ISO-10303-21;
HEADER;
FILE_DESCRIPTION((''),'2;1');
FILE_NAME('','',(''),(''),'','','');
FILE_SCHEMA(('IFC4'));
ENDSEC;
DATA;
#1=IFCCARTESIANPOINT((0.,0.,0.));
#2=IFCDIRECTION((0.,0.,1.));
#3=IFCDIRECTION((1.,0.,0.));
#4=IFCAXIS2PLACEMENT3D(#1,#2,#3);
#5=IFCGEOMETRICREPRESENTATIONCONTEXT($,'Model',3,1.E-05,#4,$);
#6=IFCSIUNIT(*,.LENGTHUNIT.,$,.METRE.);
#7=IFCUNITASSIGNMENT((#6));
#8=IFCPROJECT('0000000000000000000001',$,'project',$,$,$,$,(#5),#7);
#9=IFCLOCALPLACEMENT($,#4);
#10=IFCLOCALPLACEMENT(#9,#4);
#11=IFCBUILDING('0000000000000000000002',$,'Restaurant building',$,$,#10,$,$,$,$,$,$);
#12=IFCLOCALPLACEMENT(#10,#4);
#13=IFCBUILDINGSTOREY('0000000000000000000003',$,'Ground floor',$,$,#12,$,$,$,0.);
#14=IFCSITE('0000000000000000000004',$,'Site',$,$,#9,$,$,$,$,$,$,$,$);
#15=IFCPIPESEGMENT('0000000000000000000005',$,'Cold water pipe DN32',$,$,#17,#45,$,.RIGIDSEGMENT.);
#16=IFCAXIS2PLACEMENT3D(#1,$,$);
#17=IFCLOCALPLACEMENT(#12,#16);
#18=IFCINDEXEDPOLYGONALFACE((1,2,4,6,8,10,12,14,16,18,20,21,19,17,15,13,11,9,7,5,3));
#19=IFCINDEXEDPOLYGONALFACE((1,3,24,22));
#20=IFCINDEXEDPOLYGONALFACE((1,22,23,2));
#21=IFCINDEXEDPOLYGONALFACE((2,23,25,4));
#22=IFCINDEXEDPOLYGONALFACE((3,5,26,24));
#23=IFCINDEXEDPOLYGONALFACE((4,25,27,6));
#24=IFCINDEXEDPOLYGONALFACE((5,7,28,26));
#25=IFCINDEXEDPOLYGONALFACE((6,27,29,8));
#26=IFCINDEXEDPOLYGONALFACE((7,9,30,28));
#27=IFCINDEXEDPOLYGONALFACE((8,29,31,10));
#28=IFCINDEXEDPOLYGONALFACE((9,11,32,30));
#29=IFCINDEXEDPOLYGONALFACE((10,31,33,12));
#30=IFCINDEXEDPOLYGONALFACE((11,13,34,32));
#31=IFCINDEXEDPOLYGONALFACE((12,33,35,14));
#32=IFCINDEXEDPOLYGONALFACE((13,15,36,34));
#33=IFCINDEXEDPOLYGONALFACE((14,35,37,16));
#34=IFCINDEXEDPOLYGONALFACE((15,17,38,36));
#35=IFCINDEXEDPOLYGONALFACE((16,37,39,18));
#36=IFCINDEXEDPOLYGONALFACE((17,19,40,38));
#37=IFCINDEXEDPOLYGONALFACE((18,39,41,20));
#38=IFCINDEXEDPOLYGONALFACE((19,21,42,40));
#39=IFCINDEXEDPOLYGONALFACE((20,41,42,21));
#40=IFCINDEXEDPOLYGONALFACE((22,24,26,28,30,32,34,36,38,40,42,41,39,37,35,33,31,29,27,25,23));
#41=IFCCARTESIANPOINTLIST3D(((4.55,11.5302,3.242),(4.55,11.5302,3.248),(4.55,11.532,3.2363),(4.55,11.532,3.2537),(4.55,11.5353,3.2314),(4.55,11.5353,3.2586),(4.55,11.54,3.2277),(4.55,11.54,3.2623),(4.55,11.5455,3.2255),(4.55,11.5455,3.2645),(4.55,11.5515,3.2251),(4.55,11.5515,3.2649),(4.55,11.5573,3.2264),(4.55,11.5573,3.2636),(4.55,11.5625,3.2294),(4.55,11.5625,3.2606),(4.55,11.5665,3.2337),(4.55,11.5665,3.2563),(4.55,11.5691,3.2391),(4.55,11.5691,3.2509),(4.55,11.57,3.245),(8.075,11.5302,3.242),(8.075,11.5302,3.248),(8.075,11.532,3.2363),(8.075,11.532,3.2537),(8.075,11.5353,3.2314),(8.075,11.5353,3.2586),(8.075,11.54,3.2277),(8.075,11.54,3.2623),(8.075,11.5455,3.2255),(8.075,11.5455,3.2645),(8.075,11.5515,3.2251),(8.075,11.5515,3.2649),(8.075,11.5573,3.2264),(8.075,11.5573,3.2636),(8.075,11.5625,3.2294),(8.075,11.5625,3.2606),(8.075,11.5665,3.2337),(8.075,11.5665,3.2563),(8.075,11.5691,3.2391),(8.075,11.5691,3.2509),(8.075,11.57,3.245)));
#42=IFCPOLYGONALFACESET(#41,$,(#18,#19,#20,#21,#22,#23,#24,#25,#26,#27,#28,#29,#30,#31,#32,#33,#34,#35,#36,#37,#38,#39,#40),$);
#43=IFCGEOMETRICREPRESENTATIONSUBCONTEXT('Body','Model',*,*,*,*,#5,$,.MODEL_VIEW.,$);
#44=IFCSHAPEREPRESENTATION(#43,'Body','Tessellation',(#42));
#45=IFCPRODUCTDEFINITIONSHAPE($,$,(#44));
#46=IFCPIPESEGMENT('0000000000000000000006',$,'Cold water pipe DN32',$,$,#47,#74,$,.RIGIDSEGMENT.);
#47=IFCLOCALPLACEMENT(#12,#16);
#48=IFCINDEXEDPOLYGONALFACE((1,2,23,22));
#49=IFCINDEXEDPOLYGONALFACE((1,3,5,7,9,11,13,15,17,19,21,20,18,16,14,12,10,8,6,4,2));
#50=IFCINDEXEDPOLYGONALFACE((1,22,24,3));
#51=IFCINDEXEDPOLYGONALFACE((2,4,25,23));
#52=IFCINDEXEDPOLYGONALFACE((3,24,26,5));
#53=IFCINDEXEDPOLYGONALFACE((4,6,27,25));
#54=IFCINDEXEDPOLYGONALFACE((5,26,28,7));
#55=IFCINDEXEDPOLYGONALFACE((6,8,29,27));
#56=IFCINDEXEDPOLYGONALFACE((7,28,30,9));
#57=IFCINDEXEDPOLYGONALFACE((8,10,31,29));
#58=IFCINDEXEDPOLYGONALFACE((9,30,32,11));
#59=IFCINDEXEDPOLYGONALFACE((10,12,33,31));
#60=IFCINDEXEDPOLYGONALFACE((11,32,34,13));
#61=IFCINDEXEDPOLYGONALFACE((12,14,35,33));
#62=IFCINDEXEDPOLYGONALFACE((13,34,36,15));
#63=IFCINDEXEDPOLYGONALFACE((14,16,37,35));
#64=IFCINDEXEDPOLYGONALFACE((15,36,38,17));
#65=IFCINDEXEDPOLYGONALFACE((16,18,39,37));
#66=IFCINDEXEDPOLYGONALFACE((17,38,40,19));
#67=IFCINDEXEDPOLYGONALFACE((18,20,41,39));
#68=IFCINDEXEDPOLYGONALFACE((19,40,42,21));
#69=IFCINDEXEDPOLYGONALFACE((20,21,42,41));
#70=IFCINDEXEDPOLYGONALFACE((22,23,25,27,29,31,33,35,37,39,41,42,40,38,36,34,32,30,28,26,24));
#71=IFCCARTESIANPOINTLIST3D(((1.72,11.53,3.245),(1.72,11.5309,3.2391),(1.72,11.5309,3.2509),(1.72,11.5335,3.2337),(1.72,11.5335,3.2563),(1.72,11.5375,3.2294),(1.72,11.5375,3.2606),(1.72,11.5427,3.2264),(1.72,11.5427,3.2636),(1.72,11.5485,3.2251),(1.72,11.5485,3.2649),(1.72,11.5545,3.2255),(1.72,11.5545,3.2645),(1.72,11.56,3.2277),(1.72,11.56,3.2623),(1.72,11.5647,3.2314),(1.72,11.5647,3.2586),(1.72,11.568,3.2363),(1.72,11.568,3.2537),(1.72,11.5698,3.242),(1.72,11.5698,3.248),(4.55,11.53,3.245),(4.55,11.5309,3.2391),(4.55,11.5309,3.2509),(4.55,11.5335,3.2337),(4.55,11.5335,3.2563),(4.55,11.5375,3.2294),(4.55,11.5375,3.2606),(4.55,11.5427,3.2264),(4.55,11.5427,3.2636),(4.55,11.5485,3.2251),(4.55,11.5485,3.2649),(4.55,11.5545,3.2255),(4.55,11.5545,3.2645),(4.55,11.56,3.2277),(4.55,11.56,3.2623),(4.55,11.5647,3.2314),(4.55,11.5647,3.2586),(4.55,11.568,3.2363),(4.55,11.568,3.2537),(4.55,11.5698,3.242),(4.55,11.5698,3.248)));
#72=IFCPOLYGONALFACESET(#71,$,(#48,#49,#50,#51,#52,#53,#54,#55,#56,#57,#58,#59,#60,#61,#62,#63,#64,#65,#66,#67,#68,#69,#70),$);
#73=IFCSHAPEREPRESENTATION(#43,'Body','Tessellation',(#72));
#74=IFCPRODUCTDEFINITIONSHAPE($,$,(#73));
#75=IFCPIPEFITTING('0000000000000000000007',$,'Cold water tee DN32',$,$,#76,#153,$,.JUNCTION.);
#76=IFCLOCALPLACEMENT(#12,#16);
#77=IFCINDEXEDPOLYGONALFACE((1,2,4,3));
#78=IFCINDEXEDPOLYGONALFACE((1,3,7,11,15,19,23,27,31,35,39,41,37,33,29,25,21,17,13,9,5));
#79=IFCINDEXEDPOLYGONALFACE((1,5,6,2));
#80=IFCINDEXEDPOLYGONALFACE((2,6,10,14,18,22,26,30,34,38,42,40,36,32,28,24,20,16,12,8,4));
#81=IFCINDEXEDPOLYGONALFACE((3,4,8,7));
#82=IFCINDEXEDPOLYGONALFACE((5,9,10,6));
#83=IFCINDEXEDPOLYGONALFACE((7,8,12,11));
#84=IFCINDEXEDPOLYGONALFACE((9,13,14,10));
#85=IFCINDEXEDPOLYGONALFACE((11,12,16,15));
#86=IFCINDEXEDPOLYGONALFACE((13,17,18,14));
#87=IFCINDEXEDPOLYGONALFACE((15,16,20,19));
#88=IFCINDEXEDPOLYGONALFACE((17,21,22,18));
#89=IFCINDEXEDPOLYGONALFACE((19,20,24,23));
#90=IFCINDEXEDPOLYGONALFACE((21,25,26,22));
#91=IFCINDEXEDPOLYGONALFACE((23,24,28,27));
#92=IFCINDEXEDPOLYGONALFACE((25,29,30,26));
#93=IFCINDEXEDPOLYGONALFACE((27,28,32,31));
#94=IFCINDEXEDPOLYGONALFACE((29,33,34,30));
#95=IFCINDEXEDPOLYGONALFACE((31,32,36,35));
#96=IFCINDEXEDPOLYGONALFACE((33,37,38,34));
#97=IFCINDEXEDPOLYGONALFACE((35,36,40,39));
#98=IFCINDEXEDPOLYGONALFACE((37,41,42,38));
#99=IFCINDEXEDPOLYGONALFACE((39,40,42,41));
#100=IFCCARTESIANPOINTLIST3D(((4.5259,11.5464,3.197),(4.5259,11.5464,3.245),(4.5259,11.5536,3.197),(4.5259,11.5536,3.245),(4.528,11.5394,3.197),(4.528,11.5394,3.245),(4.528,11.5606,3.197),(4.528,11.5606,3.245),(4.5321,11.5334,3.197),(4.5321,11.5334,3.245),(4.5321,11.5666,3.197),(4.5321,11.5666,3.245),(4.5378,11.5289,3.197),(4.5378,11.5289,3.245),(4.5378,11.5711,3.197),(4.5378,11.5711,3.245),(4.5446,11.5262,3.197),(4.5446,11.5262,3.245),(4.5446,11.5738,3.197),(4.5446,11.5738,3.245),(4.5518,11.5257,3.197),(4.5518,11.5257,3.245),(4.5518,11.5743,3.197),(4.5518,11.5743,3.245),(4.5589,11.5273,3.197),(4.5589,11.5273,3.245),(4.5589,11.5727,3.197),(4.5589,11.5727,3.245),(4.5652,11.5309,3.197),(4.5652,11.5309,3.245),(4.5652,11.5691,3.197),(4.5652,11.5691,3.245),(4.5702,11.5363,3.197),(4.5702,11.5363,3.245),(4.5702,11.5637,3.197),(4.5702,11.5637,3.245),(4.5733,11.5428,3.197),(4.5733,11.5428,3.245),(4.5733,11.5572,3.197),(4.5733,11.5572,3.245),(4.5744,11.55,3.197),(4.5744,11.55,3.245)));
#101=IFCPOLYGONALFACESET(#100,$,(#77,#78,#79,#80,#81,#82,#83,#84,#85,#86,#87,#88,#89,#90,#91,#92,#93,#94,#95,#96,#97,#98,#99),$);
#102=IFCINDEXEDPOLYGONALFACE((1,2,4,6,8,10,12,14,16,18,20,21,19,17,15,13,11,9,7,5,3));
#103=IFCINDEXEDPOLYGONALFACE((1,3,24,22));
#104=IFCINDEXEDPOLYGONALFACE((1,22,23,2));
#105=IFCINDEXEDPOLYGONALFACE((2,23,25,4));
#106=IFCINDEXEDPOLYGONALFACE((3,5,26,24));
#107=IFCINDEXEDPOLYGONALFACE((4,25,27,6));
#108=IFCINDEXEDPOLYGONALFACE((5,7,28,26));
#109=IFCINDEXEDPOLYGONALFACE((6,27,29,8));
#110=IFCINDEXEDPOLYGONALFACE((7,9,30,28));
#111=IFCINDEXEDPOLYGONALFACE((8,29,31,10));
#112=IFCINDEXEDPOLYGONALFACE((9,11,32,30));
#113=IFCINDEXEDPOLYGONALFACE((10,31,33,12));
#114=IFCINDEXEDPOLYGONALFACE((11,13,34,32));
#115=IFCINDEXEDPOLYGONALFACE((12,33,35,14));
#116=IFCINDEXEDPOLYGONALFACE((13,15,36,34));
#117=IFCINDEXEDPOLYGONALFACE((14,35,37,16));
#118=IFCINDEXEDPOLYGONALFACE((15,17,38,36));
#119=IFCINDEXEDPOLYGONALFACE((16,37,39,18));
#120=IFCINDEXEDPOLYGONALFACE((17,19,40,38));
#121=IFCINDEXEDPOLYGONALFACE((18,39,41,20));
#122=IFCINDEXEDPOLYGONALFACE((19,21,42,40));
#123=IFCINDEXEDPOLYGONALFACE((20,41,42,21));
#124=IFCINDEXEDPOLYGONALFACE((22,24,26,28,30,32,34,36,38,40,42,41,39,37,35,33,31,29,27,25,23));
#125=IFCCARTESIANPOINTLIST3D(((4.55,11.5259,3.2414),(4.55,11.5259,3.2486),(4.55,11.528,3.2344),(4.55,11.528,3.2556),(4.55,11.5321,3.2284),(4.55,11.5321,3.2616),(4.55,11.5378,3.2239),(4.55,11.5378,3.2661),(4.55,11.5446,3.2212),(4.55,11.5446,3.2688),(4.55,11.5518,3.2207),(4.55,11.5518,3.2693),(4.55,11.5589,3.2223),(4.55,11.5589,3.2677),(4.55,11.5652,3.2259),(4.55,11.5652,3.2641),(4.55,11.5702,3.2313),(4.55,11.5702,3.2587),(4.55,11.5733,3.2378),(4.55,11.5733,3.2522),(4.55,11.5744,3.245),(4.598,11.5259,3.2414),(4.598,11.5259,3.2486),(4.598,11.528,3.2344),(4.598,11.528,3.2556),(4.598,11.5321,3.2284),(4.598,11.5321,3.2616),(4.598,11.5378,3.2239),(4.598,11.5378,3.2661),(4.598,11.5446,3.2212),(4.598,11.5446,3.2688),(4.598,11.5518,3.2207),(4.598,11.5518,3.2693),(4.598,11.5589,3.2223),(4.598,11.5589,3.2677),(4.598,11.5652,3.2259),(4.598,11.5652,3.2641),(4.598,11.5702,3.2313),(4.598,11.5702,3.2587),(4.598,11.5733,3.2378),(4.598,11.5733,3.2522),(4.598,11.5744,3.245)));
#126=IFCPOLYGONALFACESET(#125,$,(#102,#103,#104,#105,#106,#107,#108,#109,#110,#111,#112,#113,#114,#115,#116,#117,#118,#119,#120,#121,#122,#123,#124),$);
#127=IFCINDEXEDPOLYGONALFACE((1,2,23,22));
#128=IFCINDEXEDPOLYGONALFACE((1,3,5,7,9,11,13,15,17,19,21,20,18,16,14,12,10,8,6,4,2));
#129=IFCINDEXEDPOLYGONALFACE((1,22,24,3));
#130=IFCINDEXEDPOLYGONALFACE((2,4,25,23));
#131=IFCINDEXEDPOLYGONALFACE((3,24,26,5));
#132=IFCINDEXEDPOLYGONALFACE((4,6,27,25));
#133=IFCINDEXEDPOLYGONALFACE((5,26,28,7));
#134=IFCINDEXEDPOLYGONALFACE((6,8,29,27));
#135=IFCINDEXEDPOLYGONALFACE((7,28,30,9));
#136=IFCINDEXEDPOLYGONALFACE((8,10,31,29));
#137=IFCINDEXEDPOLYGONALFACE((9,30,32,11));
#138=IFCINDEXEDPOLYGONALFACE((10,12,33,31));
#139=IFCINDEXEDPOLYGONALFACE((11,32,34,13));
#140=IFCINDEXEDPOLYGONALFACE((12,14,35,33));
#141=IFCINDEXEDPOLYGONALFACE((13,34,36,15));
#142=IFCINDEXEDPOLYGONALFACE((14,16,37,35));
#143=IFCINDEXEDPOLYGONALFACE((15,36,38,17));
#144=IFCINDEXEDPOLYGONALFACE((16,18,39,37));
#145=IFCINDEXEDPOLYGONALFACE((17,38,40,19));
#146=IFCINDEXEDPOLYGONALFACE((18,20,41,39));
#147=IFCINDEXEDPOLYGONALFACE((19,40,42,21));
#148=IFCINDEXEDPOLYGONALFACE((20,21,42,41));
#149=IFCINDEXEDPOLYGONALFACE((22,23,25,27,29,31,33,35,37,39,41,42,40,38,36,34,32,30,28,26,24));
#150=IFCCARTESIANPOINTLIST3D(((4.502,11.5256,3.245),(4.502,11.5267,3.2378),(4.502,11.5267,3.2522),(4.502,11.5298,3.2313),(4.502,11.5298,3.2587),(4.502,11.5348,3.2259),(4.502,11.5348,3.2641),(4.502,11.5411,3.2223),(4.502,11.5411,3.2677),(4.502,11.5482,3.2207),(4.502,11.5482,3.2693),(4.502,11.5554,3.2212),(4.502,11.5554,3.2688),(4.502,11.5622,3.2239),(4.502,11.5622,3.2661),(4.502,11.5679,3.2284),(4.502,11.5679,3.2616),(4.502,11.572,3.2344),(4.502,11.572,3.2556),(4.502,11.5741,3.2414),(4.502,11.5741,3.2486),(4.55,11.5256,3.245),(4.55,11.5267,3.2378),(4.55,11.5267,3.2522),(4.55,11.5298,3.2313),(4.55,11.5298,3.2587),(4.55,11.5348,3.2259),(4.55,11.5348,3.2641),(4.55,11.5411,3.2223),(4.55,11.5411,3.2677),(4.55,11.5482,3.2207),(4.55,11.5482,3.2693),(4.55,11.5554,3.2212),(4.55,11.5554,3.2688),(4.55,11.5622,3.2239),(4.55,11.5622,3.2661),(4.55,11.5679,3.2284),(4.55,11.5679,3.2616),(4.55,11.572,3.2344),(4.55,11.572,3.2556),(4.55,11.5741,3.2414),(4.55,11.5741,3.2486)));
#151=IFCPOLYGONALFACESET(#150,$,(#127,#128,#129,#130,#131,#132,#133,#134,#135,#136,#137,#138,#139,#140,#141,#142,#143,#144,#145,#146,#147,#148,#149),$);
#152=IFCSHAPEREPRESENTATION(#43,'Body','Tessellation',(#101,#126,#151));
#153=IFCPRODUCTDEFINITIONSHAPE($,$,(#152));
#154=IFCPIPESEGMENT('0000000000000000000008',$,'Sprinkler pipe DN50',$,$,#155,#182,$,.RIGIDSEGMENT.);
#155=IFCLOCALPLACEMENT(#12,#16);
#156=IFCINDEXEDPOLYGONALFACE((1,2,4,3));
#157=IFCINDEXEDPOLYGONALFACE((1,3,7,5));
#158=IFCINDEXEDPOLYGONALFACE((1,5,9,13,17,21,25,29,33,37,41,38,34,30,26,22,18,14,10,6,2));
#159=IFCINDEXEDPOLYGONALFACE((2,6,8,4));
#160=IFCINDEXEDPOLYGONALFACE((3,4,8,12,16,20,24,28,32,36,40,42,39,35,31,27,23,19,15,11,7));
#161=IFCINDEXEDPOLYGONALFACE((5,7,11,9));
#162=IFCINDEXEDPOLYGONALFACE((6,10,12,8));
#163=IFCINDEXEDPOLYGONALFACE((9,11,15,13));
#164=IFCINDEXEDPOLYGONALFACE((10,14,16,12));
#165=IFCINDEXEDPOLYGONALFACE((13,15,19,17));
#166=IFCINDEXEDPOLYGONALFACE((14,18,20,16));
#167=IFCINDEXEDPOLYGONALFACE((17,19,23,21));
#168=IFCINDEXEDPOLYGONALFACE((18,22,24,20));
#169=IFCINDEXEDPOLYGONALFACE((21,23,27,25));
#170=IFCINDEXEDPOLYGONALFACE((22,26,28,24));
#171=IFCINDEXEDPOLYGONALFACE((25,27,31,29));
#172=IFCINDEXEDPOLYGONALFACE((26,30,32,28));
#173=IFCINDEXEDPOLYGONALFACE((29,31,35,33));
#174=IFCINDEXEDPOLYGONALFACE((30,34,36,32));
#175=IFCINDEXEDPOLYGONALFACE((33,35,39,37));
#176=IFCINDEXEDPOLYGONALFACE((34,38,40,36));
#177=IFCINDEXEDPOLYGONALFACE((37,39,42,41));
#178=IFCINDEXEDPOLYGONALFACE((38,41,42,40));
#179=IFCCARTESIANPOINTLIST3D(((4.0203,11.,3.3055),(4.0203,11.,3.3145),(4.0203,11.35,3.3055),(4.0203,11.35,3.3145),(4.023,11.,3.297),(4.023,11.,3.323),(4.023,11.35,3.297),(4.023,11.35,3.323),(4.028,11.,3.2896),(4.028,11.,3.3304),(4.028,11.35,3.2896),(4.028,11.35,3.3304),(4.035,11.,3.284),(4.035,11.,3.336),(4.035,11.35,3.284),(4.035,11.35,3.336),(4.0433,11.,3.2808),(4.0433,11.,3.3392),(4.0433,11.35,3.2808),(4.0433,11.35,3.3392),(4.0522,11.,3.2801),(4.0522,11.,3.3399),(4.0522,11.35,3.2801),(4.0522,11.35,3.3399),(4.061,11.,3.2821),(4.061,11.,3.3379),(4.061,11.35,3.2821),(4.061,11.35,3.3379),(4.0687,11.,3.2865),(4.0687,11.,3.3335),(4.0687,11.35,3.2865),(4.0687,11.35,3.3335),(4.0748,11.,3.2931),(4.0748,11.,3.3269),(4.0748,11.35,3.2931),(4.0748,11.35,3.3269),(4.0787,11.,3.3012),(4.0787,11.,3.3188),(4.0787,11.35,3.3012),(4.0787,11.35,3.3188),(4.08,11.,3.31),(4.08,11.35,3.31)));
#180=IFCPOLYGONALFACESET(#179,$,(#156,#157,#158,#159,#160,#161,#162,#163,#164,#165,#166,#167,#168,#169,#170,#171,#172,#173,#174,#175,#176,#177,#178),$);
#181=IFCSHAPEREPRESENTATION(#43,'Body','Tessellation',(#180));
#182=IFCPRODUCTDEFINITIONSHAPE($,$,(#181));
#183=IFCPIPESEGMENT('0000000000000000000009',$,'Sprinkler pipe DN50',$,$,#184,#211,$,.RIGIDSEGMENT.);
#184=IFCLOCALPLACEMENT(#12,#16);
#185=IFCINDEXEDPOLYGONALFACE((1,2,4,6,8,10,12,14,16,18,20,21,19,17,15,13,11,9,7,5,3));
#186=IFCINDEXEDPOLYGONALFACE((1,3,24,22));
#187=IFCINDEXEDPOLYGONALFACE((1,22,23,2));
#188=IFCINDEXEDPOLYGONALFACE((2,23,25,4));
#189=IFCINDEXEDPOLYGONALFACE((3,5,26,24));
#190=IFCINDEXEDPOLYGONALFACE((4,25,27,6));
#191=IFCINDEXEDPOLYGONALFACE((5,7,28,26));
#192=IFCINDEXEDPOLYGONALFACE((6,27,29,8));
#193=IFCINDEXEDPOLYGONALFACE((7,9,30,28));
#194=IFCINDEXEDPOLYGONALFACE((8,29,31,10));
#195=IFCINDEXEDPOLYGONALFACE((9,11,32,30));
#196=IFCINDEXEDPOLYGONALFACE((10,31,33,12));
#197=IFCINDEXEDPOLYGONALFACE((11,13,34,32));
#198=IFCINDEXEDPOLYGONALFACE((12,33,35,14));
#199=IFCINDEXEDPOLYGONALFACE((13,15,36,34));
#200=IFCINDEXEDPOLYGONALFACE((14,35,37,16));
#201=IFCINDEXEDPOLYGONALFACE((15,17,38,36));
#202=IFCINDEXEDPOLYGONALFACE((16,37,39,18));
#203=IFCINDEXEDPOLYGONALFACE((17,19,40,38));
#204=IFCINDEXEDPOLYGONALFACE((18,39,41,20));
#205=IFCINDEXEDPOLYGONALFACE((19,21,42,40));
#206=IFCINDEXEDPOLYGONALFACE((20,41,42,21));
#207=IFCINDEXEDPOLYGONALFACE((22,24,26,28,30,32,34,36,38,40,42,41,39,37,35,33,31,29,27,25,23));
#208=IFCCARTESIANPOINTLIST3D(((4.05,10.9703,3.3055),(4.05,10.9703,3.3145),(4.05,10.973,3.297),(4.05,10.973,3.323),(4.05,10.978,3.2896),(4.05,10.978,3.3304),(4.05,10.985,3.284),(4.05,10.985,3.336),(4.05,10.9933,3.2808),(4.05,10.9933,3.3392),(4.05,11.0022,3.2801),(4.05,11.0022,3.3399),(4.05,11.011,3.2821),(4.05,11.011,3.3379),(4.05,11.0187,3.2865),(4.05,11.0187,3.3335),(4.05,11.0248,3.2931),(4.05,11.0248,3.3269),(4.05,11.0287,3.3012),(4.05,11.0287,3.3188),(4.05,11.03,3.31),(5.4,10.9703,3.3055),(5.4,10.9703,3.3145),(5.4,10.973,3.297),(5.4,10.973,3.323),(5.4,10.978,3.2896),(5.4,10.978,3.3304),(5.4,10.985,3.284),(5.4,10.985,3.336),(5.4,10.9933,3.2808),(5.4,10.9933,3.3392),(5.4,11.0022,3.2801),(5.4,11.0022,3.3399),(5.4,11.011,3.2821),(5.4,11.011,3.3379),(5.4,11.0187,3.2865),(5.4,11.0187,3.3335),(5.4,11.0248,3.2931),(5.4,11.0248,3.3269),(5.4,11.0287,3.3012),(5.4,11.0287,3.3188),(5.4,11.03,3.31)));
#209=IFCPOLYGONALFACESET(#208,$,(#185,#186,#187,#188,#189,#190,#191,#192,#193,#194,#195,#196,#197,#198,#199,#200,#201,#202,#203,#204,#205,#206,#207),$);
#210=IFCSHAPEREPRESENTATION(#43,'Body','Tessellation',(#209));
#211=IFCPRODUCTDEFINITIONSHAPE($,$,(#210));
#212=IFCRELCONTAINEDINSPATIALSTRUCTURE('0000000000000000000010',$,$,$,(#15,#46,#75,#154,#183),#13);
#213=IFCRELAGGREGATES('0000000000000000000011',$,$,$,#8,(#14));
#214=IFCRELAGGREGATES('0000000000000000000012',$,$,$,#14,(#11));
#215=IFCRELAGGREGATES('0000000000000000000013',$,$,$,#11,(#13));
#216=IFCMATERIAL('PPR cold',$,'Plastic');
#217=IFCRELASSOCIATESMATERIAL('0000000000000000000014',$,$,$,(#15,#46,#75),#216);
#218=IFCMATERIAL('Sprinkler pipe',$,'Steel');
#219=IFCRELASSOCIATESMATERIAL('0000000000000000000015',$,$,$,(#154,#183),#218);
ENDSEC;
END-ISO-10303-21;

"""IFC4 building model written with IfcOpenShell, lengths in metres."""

from ifc_helpers import new_model, si_unit, frame, origin_with_axes, origin_2d, place, context, subcontext, project, spatial, circle, extrude, material, element, save


model = new_model("IFC4")

# Units and contexts
model_context = context("Model", 3, precision=1e-05, world=origin_with_axes())
body_context = subcontext(model_context, "Body", "Model", "MODEL_VIEW")
ifc_project = project(units=[si_unit("LENGTHUNIT", "METRE")], contexts=[model_context])

# Site, building, storey
site_placement = place(None, origin_with_axes())
site = spatial("IfcSite", under=ifc_project, at=site_placement, Name="Site")
building_placement = place(site_placement, origin_with_axes())
building = spatial("IfcBuilding", under=site, at=building_placement, Name="Restaurant building")
storey_placement = place(building_placement, origin_with_axes())
storey = spatial("IfcBuildingStorey", under=building, at=storey_placement, Name="Ground floor", Elevation=0.0)

# Pipe segments
ifc_material_1 = material(Name="PPR cold", Category="Plastic")
pipe_segment_1_placement = place(storey_placement, frame((4.55, 11.55, 3.245)))
element("IfcPipeSegment", 1, at=pipe_segment_1_placement, inside=storey, material=ifc_material_1, Name="Cold water pipe DN32", PredefinedType="RIGIDSEGMENT", context=body_context, shape_type="SweptSolid", body=[
    extrude(circle(Radius=0.02, at=origin_2d()), frame((0.0, 0.0, 0.0), z_axis=(1.0, 0.0, 0.0), x_axis=(0.0, 1.0, 0.0)), (0.0, 0.0, 1.0), 3.525),
])
pipe_segment_2_placement = place(storey_placement, frame((4.55, 11.55, 3.245)))
element("IfcPipeSegment", 2, at=pipe_segment_2_placement, inside=storey, material=ifc_material_1, Name="Cold water pipe DN32", PredefinedType="RIGIDSEGMENT", context=body_context, shape_type="SweptSolid", body=[
    extrude(circle(Radius=0.02, at=origin_2d()), frame((0.0, 0.0, 0.0), z_axis=(-1.0, 0.0, 0.0), x_axis=(0.0, -1.0, 0.0)), (0.0, 0.0, 1.0), 2.83),
])

# Pipe fitting
pipe_fitting_1_placement = place(storey_placement, frame((4.55, 11.55, 3.245)))
element("IfcPipeFitting", 3, at=pipe_fitting_1_placement, inside=storey, material=ifc_material_1, Name="Cold water tee DN32", PredefinedType="JUNCTION", context=body_context, shape_type="SweptSolid", body=[
    extrude(circle(Radius=0.0244, at=origin_2d()), frame((0.0, 0.0, 0.0), z_axis=(0.0, 0.0, -1.0), x_axis=(1.0, 0.0, 0.0)), (0.0, 0.0, 1.0), 0.048),
    extrude(circle(Radius=0.0244, at=origin_2d()), frame((0.0, 0.0, 0.0), z_axis=(1.0, 0.0, 0.0), x_axis=(0.0, 1.0, 0.0)), (0.0, 0.0, 1.0), 0.048),
    extrude(circle(Radius=0.0244, at=origin_2d()), frame((0.0, 0.0, 0.0), z_axis=(-1.0, 0.0, 0.0), x_axis=(0.0, -1.0, 0.0)), (0.0, 0.0, 1.0), 0.048),
])

# Pipe segments
ifc_material_2 = material(Name="Sprinkler pipe", Category="Steel")
pipe_segment_3_placement = place(storey_placement, frame((4.05, 11.35, 3.31)))
element("IfcPipeSegment", 4, at=pipe_segment_3_placement, inside=storey, material=ifc_material_2, Name="Sprinkler pipe DN50", PredefinedType="RIGIDSEGMENT", context=body_context, shape_type="SweptSolid", body=[
    extrude(circle(Radius=0.03, at=origin_2d()), frame((0.0, 0.0, 0.0), z_axis=(0.0, -1.0, 0.0), x_axis=(1.0, 0.0, 0.0)), (0.0, 0.0, 1.0), 0.35),
])
pipe_segment_4_placement = place(storey_placement, frame((4.05, 11.0, 3.31)))
element("IfcPipeSegment", 5, at=pipe_segment_4_placement, inside=storey, material=ifc_material_2, Name="Sprinkler pipe DN50", PredefinedType="RIGIDSEGMENT", context=body_context, shape_type="SweptSolid", body=[
    extrude(circle(Radius=0.03, at=origin_2d()), frame((0.0, 0.0, 0.0), z_axis=(1.0, 0.0, 0.0), x_axis=(0.0, 1.0, 0.0)), (0.0, 0.0, 1.0), 1.35),
])

save(model, "model.ifc")
